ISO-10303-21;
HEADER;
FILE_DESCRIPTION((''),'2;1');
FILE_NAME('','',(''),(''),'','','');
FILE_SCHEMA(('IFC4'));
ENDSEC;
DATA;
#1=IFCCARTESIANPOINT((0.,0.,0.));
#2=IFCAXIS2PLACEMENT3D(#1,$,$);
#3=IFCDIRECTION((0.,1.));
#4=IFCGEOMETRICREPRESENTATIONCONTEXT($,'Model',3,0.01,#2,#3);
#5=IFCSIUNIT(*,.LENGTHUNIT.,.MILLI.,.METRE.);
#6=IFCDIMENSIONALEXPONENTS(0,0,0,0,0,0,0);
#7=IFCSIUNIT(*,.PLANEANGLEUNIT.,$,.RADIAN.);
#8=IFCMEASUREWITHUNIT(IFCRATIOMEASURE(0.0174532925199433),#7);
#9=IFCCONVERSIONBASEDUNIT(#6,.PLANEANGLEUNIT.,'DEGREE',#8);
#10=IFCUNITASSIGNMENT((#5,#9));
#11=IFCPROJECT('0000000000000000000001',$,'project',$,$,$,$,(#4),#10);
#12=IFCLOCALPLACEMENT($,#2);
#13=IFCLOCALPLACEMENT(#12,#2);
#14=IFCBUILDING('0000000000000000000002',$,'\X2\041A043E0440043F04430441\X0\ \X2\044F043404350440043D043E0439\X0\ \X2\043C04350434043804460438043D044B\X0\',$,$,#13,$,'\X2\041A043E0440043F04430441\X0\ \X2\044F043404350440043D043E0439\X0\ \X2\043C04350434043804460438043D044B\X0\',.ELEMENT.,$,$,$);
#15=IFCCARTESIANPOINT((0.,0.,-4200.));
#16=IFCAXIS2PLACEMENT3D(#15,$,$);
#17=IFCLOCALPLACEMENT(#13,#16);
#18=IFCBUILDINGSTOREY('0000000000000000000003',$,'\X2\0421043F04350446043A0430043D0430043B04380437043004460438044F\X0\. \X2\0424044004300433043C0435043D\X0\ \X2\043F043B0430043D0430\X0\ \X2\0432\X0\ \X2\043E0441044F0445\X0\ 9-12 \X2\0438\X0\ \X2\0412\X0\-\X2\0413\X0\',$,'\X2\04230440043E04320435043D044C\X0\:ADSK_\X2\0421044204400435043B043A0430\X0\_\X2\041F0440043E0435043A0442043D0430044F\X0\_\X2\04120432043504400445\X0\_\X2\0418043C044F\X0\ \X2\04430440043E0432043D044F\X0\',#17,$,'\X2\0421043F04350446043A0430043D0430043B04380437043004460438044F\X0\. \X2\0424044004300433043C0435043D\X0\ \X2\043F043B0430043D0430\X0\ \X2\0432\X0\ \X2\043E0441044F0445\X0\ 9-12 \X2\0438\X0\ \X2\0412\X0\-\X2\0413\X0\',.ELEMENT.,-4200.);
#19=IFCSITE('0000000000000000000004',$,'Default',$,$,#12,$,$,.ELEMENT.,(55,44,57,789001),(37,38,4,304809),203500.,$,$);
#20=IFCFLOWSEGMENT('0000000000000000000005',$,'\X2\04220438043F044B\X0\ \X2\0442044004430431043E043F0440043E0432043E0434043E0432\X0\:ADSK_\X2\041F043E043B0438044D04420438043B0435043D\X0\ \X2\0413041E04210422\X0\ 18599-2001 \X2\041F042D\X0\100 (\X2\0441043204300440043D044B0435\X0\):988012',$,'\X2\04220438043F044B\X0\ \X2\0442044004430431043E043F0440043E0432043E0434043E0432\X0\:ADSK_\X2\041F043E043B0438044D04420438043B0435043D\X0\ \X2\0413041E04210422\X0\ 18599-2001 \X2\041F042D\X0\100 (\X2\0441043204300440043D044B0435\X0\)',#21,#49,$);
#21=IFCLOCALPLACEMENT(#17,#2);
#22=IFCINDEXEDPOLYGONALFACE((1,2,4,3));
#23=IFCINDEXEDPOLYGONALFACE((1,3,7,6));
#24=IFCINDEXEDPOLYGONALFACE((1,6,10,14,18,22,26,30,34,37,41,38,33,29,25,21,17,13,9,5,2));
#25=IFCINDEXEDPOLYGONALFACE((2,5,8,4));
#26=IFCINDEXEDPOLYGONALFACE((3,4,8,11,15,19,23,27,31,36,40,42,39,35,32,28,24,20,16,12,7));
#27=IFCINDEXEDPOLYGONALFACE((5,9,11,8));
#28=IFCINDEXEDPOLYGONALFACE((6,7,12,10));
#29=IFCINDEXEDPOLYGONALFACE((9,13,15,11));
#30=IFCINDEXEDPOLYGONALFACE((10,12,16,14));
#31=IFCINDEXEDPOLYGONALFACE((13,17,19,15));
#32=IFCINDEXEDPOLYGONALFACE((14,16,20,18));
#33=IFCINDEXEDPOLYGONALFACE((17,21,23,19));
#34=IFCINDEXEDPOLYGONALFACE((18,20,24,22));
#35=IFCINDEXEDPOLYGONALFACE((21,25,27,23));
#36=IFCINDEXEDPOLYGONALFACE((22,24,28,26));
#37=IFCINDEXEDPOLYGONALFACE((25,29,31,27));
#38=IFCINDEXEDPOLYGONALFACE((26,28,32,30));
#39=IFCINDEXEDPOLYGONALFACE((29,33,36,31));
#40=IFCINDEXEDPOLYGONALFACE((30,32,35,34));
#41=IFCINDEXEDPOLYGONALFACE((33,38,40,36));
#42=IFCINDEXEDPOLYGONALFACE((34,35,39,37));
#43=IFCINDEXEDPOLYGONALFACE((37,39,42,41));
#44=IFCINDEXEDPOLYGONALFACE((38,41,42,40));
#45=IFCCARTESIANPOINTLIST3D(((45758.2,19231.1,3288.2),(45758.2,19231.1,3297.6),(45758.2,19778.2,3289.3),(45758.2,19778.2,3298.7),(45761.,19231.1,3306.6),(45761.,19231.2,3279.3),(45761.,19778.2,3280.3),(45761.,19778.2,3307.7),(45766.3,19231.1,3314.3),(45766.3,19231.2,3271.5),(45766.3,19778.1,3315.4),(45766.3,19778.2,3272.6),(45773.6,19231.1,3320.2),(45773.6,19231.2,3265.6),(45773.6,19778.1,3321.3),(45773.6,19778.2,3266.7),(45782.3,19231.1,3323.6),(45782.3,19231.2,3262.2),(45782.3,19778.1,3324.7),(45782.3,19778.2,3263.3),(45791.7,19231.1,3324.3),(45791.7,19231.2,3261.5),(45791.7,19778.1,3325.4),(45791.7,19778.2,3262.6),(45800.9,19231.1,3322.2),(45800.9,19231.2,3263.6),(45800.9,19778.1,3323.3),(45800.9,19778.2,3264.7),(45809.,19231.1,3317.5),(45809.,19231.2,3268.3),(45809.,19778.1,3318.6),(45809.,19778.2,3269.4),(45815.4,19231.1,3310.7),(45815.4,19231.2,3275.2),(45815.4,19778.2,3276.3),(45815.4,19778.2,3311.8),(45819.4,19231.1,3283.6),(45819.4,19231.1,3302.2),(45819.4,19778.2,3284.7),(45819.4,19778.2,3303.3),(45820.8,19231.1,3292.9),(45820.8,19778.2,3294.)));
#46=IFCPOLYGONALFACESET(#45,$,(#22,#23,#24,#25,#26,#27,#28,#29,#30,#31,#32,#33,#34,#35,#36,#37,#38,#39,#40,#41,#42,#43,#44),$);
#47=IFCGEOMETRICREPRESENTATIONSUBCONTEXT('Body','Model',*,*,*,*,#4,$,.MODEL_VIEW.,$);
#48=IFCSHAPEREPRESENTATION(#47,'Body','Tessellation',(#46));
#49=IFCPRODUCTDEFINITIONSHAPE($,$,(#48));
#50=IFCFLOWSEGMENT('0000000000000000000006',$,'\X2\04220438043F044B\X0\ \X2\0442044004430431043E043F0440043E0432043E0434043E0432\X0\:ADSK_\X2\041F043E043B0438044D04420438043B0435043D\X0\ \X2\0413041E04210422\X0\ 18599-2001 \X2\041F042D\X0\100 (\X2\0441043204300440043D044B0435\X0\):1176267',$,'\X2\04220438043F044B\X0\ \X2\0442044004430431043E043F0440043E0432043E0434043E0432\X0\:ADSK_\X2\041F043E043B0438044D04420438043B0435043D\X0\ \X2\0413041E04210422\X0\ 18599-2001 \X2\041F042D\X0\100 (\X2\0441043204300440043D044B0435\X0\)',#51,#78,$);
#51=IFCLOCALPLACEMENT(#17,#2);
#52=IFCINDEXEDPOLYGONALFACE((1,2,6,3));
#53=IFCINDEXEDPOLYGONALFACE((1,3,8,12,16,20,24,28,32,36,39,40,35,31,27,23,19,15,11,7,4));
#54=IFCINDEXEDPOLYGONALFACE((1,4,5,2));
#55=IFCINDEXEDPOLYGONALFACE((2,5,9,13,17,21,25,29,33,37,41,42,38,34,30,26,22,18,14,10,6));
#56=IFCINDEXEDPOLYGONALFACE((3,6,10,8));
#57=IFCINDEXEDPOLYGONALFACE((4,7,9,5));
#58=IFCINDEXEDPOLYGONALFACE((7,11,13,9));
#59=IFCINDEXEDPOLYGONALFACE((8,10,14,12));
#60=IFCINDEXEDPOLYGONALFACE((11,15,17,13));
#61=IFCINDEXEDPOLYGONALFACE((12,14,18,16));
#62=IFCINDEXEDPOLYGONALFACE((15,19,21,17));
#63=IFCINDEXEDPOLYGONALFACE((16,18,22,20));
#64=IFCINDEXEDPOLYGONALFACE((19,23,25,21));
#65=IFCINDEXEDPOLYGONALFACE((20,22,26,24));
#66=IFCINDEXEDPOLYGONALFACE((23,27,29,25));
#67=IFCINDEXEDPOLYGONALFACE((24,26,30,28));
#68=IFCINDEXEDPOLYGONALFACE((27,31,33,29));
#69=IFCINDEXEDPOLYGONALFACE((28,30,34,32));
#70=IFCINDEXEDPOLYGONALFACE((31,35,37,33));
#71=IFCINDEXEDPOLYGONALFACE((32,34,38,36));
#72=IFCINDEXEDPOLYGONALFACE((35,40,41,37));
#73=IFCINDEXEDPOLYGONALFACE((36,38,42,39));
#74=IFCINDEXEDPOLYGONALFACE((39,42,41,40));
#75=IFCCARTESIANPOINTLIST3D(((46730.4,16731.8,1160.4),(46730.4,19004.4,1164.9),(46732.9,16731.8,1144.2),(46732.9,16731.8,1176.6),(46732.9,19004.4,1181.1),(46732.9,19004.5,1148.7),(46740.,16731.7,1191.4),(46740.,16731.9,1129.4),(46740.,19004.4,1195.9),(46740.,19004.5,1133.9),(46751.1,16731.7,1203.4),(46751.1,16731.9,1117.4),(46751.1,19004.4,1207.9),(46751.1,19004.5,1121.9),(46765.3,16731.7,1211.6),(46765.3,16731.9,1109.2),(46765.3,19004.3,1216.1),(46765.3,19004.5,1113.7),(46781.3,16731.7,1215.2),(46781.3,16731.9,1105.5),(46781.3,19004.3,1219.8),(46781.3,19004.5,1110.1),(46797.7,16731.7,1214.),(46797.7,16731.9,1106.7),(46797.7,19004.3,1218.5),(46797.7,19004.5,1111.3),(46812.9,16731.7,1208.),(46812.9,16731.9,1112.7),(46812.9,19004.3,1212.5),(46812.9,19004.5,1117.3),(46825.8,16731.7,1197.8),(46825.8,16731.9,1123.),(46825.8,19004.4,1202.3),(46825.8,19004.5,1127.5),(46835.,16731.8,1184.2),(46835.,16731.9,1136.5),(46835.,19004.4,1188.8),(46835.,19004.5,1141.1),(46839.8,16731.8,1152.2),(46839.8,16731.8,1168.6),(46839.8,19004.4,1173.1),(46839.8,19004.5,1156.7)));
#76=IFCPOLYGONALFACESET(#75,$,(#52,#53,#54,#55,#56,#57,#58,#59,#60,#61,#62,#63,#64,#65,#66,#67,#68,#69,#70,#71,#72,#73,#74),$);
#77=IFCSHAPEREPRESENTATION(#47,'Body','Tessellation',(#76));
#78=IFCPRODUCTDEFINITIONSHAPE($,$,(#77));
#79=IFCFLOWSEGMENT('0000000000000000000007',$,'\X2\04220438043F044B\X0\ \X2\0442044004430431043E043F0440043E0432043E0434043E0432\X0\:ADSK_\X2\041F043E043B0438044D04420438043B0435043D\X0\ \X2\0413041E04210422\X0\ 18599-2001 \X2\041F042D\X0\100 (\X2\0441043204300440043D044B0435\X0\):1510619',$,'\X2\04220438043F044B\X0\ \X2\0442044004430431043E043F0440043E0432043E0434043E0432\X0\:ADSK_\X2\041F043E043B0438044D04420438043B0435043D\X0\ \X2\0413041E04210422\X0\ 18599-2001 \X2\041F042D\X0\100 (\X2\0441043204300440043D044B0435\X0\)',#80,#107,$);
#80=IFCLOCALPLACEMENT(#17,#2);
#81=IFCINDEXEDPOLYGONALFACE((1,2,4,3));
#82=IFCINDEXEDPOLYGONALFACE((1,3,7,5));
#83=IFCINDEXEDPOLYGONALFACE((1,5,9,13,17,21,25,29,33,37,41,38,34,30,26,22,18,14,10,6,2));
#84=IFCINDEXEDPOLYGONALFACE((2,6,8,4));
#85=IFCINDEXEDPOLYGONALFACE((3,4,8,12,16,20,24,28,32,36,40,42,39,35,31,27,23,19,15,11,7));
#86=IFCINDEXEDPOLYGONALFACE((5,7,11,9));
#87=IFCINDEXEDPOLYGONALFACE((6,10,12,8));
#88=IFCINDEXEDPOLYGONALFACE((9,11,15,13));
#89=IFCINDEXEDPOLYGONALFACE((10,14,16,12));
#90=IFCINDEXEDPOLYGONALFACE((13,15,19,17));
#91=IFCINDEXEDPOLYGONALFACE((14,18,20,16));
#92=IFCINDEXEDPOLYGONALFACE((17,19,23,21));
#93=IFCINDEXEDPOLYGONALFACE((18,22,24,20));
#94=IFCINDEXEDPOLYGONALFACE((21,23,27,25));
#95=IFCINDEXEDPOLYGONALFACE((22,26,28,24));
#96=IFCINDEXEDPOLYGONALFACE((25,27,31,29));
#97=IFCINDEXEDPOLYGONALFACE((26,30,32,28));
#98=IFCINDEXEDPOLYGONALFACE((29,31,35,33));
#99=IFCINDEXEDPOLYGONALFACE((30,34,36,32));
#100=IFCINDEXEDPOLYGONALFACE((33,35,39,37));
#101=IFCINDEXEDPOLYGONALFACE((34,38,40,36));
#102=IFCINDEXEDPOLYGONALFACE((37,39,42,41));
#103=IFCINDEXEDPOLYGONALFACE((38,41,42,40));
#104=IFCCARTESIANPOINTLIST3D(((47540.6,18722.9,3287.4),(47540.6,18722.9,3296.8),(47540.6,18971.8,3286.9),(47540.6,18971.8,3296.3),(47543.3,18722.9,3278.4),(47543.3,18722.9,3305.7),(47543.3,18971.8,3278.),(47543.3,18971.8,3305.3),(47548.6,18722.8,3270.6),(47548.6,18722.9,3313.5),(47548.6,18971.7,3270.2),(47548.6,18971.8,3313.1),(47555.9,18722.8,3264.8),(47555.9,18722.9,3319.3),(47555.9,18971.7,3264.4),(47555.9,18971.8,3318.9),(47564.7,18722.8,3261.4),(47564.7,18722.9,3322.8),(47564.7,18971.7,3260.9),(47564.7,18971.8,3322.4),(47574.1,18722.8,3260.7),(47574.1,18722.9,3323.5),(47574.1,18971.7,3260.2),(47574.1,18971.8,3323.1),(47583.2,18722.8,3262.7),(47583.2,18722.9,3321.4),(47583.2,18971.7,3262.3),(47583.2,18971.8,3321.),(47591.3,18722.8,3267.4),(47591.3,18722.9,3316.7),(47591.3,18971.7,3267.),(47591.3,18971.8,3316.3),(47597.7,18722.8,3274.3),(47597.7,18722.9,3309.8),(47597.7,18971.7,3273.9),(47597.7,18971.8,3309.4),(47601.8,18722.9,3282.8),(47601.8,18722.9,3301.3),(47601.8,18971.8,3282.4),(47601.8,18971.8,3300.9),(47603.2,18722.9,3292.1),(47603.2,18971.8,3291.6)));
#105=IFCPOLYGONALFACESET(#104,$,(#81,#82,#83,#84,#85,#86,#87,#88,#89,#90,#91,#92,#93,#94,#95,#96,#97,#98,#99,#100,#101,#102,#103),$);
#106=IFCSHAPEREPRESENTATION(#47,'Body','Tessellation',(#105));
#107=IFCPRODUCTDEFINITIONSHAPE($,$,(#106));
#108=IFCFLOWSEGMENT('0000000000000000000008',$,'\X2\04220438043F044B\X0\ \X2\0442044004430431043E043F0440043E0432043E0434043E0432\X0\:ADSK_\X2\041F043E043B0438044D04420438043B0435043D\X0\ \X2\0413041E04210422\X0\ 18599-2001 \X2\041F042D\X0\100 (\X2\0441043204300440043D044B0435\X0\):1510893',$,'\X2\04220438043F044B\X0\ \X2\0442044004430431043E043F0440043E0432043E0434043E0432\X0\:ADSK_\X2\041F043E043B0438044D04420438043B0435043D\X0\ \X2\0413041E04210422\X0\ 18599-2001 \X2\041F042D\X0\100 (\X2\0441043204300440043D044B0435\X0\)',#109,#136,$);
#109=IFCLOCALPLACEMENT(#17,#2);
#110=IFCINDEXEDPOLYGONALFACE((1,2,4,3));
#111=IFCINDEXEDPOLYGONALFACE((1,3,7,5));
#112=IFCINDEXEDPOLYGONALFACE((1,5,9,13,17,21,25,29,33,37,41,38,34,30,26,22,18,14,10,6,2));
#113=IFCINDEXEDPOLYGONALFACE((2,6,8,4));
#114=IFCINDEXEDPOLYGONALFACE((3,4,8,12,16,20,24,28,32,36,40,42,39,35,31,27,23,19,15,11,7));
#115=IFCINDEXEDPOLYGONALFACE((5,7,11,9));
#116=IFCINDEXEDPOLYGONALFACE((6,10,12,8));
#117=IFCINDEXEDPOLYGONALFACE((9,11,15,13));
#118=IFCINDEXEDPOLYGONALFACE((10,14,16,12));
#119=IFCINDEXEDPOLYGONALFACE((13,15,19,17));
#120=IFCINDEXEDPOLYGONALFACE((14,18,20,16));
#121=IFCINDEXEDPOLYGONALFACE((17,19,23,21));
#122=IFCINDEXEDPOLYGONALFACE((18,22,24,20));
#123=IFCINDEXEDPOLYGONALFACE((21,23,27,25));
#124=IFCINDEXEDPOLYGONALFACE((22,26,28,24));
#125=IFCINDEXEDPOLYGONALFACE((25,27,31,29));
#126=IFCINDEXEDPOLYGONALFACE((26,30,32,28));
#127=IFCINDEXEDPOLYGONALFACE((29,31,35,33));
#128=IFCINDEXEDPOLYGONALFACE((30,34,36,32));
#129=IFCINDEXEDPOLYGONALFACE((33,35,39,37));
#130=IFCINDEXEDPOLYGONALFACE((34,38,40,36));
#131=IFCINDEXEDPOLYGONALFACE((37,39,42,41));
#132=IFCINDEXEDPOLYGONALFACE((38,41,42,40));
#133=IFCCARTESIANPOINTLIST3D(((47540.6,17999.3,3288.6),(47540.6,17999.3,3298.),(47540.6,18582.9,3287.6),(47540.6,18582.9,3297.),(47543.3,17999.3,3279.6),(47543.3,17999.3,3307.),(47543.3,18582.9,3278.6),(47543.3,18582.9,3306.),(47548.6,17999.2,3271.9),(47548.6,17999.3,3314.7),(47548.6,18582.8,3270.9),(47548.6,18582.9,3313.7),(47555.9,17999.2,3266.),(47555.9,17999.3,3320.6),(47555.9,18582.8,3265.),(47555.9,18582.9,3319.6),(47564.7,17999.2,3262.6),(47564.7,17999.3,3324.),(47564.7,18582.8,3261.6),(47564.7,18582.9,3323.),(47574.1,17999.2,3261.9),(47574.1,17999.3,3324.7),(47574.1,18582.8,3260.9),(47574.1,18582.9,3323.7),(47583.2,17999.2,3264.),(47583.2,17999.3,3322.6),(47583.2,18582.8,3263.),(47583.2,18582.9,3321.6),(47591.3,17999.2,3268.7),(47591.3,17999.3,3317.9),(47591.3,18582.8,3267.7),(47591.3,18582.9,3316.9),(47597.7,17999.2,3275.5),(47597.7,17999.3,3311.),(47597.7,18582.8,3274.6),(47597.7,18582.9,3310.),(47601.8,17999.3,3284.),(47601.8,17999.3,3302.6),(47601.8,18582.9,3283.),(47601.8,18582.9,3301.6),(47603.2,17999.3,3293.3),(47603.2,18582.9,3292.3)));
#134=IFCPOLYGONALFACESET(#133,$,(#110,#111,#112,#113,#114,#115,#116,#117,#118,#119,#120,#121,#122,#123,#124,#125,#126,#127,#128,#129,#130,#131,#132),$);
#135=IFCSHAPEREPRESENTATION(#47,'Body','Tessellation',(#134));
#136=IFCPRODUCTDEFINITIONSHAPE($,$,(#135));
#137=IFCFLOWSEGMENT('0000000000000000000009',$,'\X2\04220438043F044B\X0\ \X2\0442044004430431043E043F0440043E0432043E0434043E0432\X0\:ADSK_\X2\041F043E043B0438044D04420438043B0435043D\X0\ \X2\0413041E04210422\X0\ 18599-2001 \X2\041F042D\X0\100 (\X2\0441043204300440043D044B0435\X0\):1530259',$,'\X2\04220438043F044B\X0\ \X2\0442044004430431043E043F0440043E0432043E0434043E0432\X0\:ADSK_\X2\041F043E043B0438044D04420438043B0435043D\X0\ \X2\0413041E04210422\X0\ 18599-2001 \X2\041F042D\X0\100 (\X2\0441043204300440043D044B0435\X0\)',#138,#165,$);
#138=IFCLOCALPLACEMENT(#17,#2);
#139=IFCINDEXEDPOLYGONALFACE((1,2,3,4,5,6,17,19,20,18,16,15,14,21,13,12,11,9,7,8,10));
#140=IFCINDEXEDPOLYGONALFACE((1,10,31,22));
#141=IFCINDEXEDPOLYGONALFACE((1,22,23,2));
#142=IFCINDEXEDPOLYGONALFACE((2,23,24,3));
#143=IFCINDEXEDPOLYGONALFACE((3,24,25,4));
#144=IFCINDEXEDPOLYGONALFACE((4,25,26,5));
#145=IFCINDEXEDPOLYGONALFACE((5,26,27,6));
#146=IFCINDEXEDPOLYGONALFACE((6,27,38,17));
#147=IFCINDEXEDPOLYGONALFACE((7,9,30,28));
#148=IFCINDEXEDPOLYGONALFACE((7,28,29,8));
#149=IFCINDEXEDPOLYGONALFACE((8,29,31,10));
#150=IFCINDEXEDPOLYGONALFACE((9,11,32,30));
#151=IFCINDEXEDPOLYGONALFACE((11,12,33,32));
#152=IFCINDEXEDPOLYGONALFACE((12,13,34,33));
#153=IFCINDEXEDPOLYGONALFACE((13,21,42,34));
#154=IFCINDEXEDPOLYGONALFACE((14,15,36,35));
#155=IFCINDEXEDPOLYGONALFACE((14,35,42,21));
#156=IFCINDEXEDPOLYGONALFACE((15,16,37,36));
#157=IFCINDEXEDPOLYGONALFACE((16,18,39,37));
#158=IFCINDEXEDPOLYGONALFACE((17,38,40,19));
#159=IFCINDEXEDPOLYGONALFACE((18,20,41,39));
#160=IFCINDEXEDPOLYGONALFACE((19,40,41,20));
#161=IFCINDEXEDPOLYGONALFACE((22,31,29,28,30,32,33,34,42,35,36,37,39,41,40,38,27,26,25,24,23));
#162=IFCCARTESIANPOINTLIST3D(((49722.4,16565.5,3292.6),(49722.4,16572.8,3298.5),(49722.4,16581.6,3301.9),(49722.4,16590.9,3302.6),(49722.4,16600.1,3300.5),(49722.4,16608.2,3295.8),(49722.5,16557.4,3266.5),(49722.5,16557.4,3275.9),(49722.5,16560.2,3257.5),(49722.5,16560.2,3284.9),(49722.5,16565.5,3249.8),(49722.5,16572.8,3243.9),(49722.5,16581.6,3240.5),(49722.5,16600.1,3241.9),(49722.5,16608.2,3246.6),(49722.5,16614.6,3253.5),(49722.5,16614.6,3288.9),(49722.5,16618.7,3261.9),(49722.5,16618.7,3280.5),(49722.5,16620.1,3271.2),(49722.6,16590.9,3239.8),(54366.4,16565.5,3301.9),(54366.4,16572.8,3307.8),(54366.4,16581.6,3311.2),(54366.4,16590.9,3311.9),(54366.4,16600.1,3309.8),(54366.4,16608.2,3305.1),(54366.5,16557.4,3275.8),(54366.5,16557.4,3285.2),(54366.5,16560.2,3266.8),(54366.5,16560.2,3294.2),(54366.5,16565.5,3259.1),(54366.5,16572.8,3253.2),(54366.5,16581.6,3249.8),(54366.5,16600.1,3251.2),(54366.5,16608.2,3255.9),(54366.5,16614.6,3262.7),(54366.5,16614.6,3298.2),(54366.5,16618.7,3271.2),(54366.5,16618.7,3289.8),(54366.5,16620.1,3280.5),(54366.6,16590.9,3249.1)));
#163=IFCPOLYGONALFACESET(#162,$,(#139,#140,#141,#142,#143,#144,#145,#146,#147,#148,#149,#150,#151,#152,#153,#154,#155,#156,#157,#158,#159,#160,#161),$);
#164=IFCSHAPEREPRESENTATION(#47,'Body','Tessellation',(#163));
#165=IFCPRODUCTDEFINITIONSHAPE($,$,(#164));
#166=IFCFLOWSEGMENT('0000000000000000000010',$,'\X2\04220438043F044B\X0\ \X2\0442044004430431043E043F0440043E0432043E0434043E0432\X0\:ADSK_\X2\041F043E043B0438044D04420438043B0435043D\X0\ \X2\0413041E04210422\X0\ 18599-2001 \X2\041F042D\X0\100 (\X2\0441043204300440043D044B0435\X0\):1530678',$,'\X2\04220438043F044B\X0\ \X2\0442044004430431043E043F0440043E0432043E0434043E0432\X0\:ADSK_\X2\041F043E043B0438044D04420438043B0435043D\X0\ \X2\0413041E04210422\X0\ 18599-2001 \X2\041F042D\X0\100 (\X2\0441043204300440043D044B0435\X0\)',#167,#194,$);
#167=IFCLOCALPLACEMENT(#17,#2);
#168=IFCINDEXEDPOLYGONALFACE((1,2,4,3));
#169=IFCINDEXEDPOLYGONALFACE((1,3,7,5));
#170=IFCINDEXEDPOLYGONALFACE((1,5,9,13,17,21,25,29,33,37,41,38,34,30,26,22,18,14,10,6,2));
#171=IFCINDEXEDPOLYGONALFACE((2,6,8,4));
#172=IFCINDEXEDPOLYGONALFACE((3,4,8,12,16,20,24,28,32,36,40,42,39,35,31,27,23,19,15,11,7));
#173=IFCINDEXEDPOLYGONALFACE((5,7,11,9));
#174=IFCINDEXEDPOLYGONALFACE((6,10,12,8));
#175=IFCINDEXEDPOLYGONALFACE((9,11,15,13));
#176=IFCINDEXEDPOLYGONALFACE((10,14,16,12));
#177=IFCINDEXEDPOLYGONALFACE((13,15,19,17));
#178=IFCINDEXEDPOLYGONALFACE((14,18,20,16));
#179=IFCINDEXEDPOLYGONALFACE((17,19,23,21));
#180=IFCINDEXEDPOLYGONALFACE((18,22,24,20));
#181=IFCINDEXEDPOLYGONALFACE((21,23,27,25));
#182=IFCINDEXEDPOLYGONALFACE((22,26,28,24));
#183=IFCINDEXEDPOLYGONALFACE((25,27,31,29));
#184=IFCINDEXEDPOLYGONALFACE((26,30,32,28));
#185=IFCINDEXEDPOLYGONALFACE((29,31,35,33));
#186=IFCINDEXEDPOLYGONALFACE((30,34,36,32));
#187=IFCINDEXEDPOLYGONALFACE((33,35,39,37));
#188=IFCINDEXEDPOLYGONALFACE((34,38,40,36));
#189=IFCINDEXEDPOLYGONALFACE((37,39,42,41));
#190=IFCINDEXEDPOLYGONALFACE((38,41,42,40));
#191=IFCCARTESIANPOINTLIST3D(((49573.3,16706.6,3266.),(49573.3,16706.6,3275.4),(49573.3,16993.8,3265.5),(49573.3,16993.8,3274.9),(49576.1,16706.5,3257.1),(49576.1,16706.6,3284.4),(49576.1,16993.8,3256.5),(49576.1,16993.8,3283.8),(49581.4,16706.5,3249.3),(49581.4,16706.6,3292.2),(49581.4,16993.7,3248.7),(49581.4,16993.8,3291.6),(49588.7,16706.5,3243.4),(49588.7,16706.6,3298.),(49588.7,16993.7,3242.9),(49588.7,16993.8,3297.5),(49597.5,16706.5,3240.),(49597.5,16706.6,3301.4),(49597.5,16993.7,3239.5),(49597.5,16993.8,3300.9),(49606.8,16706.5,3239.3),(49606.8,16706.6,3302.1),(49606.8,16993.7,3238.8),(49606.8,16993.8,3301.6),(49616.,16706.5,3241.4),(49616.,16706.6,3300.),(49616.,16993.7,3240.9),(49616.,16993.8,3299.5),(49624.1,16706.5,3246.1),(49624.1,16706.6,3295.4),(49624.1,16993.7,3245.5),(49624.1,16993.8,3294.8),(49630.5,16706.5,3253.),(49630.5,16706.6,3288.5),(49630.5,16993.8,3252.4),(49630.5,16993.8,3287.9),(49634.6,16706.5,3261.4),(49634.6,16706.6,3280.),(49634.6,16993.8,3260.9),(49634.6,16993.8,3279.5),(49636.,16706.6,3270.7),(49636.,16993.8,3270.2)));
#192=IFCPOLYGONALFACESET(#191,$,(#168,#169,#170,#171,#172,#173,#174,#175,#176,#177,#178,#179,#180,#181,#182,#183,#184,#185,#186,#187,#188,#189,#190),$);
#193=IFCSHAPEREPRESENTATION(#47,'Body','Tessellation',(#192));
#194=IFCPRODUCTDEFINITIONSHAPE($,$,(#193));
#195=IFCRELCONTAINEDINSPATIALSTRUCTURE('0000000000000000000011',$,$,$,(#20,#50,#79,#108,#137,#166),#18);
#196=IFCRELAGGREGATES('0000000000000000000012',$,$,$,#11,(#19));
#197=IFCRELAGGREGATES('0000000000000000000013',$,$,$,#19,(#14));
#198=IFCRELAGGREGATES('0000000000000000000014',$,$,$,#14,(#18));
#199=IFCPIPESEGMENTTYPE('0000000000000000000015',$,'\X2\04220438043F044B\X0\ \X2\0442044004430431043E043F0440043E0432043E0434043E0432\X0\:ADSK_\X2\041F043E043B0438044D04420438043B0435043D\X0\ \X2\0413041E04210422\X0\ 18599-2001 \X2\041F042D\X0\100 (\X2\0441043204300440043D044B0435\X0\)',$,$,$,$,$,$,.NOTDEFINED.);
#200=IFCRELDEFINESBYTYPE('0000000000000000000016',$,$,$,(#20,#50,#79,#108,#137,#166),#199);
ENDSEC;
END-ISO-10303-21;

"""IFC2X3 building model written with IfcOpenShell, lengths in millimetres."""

from ifc_helpers import new_model, entity, si_unit, converted_unit, direction, frame, frame_2d, origin, origin_2d_with_axis, place, context, subcontext, project, spatial, circle, extrude, type_object, element, save


model = new_model("IFC2X3")

# Units and contexts
model_context = context("Model", 3, precision=0.01, world=origin(), true_north=direction((0.0, 1.0)))
body_context = subcontext(model_context, "Body", "Model", "MODEL_VIEW")
ifc_project = project(units=[si_unit("LENGTHUNIT", "METRE", prefix="MILLI"), converted_unit("PLANEANGLEUNIT", "DEGREE", entity("IfcRatioMeasure", 0.0174532925199433), si_unit("PLANEANGLEUNIT", "RADIAN"), dimensions=[0, 0, 0, 0, 0, 0, 0])], contexts=[model_context])

# Site, building, storey
site_placement = place(None, frame((0.0, 0.0, 0.0)))
site = spatial("IfcSite", under=ifc_project, at=site_placement, Name="Default", CompositionType="ELEMENT", RefLatitude=(55, 44, 57, 789001), RefLongitude=(37, 38, 4, 304809), RefElevation=203500.0)
building_placement = place(site_placement, origin())
building = spatial("IfcBuilding", under=site, at=building_placement, Name="Корпус ядерной медицины", LongName="Корпус ядерной медицины", CompositionType="ELEMENT")
storey_placement = place(building_placement, frame((0.0, 0.0, -4200.0)))
storey = spatial("IfcBuildingStorey", under=building, at=storey_placement, Name="Спецканализация. Фрагмен плана в осях 9-12 и В-Г", ObjectType="Уровень:ADSK_Стрелка_Проектная_Вверх_Имя уровня", LongName="Спецканализация. Фрагмен плана в осях 9-12 и В-Г", CompositionType="ELEMENT", Elevation=-4200.0)

# Flow segments
pipe_segment_type = type_object("IfcPipeSegmentType", Name="Типы трубопроводов:ADSK_Полиэтилен ГОСТ 18599-2001 ПЭ100 (сварные)", PredefinedType="NOTDEFINED")
flow_segment_1_placement = place(storey_placement, frame((45756.3, 19231.1, 3259.8)))
element("IfcFlowSegment", 1, at=flow_segment_1_placement, inside=storey, type_object=pipe_segment_type, Name="Типы трубопроводов:ADSK_Полиэтилен ГОСТ 18599-2001 ПЭ100 (сварные):988012", ObjectType="Типы трубопроводов:ADSK_Полиэтилен ГОСТ 18599-2001 ПЭ100 (сварные)", context=body_context, shape_type="SweptSolid", body=[
    extrude(circle(Radius=31.5, at=origin_2d_with_axis()), frame((33.1, 0.1, 33.1), z_axis=(0.0, 0.999998, 0.002), x_axis=(1.0, 0.0, 0.0)), (0.0, 0.0, 1.0), 547.1),
])
flow_segment_2_placement = place(storey_placement, frame((46728.8, 16731.7, 1103.8)))
element("IfcFlowSegment", 2, at=flow_segment_2_placement, inside=storey, type_object=pipe_segment_type, Name="Типы трубопроводов:ADSK_Полиэтилен ГОСТ 18599-2001 ПЭ100 (сварные):1176267", ObjectType="Типы трубопроводов:ADSK_Полиэтилен ГОСТ 18599-2001 ПЭ100 (сварные)", context=body_context, shape_type="SweptSolid", body=[
    extrude(circle(Radius=55.0, at=origin_2d_with_axis()), frame((56.6, 0.1, 56.6), z_axis=(0.0, 0.999998, 0.002), x_axis=(-1.0, 0.0, 0.0)), (0.0, 0.0, 1.0), 2272.6),
])
flow_segment_3_placement = place(storey_placement, frame((47538.6, 18722.8, 3258.5)))
element("IfcFlowSegment", 3, at=flow_segment_3_placement, inside=storey, type_object=pipe_segment_type, Name="Типы трубопроводов:ADSK_Полиэтилен ГОСТ 18599-2001 ПЭ100 (сварные):1510619", ObjectType="Типы трубопроводов:ADSK_Полиэтилен ГОСТ 18599-2001 ПЭ100 (сварные)", context=body_context, shape_type="SweptSolid", body=[
    extrude(circle(Radius=31.5, at=origin_2d_with_axis()), frame((33.1, 249.0, 33.1), z_axis=(-0.000001, -0.999999, 0.001698), x_axis=(1.0, -0.000001, 0.0)), (0.0, 0.0, 1.0), 248.9),
])
flow_segment_4_placement = place(storey_placement, frame((47538.6, 17999.2, 3259.2)))
element("IfcFlowSegment", 4, at=flow_segment_4_placement, inside=storey, type_object=pipe_segment_type, Name="Типы трубопроводов:ADSK_Полиэтилен ГОСТ 18599-2001 ПЭ100 (сварные):1510893", ObjectType="Типы трубопроводов:ADSK_Полиэтилен ГОСТ 18599-2001 ПЭ100 (сварные)", context=body_context, shape_type="SweptSolid", body=[
    extrude(circle(Radius=31.5, at=origin_2d_with_axis()), frame((33.1, 583.7, 33.1), z_axis=(-0.000001, -0.999999, 0.001698), x_axis=(1.0, -0.000001, 0.0)), (0.0, 0.0, 1.0), 583.6),
])
flow_segment_5_placement = place(storey_placement, frame((49722.4, 16555.5, 3238.1)))
element("IfcFlowSegment", 5, at=flow_segment_5_placement, inside=storey, type_object=pipe_segment_type, Name="Типы трубопроводов:ADSK_Полиэтилен ГОСТ 18599-2001 ПЭ100 (сварные):1530259", ObjectType="Типы трубопроводов:ADSK_Полиэтилен ГОСТ 18599-2001 ПЭ100 (сварные)", context=body_context, shape_type="SweptSolid", body=[
    extrude(circle(Radius=31.5, at=frame_2d((0.0, 0.0), x_axis=(1.0, 0.0))), frame((0.1, 33.1, 33.1), z_axis=(0.999998, 0.0, 0.002001), x_axis=(0.0, 1.0, 0.0)), (0.0, 0.0, 1.0), 4644.0),
])
flow_segment_6_placement = place(storey_placement, frame((49571.4, 16706.5, 3237.1)))
element("IfcFlowSegment", 6, at=flow_segment_6_placement, inside=storey, type_object=pipe_segment_type, Name="Типы трубопроводов:ADSK_Полиэтилен ГОСТ 18599-2001 ПЭ100 (сварные):1530678", ObjectType="Типы трубопроводов:ADSK_Полиэтилен ГОСТ 18599-2001 ПЭ100 (сварные)", context=body_context, shape_type="SweptSolid", body=[
    extrude(circle(Radius=31.5, at=origin_2d_with_axis()), frame((33.1, 0.1, 33.6), z_axis=(0.0, 0.999998, -0.001921), x_axis=(1.0, 0.0, 0.0)), (0.0, 0.0, 1.0), 287.2),
])

save(model, "model.ifc")
